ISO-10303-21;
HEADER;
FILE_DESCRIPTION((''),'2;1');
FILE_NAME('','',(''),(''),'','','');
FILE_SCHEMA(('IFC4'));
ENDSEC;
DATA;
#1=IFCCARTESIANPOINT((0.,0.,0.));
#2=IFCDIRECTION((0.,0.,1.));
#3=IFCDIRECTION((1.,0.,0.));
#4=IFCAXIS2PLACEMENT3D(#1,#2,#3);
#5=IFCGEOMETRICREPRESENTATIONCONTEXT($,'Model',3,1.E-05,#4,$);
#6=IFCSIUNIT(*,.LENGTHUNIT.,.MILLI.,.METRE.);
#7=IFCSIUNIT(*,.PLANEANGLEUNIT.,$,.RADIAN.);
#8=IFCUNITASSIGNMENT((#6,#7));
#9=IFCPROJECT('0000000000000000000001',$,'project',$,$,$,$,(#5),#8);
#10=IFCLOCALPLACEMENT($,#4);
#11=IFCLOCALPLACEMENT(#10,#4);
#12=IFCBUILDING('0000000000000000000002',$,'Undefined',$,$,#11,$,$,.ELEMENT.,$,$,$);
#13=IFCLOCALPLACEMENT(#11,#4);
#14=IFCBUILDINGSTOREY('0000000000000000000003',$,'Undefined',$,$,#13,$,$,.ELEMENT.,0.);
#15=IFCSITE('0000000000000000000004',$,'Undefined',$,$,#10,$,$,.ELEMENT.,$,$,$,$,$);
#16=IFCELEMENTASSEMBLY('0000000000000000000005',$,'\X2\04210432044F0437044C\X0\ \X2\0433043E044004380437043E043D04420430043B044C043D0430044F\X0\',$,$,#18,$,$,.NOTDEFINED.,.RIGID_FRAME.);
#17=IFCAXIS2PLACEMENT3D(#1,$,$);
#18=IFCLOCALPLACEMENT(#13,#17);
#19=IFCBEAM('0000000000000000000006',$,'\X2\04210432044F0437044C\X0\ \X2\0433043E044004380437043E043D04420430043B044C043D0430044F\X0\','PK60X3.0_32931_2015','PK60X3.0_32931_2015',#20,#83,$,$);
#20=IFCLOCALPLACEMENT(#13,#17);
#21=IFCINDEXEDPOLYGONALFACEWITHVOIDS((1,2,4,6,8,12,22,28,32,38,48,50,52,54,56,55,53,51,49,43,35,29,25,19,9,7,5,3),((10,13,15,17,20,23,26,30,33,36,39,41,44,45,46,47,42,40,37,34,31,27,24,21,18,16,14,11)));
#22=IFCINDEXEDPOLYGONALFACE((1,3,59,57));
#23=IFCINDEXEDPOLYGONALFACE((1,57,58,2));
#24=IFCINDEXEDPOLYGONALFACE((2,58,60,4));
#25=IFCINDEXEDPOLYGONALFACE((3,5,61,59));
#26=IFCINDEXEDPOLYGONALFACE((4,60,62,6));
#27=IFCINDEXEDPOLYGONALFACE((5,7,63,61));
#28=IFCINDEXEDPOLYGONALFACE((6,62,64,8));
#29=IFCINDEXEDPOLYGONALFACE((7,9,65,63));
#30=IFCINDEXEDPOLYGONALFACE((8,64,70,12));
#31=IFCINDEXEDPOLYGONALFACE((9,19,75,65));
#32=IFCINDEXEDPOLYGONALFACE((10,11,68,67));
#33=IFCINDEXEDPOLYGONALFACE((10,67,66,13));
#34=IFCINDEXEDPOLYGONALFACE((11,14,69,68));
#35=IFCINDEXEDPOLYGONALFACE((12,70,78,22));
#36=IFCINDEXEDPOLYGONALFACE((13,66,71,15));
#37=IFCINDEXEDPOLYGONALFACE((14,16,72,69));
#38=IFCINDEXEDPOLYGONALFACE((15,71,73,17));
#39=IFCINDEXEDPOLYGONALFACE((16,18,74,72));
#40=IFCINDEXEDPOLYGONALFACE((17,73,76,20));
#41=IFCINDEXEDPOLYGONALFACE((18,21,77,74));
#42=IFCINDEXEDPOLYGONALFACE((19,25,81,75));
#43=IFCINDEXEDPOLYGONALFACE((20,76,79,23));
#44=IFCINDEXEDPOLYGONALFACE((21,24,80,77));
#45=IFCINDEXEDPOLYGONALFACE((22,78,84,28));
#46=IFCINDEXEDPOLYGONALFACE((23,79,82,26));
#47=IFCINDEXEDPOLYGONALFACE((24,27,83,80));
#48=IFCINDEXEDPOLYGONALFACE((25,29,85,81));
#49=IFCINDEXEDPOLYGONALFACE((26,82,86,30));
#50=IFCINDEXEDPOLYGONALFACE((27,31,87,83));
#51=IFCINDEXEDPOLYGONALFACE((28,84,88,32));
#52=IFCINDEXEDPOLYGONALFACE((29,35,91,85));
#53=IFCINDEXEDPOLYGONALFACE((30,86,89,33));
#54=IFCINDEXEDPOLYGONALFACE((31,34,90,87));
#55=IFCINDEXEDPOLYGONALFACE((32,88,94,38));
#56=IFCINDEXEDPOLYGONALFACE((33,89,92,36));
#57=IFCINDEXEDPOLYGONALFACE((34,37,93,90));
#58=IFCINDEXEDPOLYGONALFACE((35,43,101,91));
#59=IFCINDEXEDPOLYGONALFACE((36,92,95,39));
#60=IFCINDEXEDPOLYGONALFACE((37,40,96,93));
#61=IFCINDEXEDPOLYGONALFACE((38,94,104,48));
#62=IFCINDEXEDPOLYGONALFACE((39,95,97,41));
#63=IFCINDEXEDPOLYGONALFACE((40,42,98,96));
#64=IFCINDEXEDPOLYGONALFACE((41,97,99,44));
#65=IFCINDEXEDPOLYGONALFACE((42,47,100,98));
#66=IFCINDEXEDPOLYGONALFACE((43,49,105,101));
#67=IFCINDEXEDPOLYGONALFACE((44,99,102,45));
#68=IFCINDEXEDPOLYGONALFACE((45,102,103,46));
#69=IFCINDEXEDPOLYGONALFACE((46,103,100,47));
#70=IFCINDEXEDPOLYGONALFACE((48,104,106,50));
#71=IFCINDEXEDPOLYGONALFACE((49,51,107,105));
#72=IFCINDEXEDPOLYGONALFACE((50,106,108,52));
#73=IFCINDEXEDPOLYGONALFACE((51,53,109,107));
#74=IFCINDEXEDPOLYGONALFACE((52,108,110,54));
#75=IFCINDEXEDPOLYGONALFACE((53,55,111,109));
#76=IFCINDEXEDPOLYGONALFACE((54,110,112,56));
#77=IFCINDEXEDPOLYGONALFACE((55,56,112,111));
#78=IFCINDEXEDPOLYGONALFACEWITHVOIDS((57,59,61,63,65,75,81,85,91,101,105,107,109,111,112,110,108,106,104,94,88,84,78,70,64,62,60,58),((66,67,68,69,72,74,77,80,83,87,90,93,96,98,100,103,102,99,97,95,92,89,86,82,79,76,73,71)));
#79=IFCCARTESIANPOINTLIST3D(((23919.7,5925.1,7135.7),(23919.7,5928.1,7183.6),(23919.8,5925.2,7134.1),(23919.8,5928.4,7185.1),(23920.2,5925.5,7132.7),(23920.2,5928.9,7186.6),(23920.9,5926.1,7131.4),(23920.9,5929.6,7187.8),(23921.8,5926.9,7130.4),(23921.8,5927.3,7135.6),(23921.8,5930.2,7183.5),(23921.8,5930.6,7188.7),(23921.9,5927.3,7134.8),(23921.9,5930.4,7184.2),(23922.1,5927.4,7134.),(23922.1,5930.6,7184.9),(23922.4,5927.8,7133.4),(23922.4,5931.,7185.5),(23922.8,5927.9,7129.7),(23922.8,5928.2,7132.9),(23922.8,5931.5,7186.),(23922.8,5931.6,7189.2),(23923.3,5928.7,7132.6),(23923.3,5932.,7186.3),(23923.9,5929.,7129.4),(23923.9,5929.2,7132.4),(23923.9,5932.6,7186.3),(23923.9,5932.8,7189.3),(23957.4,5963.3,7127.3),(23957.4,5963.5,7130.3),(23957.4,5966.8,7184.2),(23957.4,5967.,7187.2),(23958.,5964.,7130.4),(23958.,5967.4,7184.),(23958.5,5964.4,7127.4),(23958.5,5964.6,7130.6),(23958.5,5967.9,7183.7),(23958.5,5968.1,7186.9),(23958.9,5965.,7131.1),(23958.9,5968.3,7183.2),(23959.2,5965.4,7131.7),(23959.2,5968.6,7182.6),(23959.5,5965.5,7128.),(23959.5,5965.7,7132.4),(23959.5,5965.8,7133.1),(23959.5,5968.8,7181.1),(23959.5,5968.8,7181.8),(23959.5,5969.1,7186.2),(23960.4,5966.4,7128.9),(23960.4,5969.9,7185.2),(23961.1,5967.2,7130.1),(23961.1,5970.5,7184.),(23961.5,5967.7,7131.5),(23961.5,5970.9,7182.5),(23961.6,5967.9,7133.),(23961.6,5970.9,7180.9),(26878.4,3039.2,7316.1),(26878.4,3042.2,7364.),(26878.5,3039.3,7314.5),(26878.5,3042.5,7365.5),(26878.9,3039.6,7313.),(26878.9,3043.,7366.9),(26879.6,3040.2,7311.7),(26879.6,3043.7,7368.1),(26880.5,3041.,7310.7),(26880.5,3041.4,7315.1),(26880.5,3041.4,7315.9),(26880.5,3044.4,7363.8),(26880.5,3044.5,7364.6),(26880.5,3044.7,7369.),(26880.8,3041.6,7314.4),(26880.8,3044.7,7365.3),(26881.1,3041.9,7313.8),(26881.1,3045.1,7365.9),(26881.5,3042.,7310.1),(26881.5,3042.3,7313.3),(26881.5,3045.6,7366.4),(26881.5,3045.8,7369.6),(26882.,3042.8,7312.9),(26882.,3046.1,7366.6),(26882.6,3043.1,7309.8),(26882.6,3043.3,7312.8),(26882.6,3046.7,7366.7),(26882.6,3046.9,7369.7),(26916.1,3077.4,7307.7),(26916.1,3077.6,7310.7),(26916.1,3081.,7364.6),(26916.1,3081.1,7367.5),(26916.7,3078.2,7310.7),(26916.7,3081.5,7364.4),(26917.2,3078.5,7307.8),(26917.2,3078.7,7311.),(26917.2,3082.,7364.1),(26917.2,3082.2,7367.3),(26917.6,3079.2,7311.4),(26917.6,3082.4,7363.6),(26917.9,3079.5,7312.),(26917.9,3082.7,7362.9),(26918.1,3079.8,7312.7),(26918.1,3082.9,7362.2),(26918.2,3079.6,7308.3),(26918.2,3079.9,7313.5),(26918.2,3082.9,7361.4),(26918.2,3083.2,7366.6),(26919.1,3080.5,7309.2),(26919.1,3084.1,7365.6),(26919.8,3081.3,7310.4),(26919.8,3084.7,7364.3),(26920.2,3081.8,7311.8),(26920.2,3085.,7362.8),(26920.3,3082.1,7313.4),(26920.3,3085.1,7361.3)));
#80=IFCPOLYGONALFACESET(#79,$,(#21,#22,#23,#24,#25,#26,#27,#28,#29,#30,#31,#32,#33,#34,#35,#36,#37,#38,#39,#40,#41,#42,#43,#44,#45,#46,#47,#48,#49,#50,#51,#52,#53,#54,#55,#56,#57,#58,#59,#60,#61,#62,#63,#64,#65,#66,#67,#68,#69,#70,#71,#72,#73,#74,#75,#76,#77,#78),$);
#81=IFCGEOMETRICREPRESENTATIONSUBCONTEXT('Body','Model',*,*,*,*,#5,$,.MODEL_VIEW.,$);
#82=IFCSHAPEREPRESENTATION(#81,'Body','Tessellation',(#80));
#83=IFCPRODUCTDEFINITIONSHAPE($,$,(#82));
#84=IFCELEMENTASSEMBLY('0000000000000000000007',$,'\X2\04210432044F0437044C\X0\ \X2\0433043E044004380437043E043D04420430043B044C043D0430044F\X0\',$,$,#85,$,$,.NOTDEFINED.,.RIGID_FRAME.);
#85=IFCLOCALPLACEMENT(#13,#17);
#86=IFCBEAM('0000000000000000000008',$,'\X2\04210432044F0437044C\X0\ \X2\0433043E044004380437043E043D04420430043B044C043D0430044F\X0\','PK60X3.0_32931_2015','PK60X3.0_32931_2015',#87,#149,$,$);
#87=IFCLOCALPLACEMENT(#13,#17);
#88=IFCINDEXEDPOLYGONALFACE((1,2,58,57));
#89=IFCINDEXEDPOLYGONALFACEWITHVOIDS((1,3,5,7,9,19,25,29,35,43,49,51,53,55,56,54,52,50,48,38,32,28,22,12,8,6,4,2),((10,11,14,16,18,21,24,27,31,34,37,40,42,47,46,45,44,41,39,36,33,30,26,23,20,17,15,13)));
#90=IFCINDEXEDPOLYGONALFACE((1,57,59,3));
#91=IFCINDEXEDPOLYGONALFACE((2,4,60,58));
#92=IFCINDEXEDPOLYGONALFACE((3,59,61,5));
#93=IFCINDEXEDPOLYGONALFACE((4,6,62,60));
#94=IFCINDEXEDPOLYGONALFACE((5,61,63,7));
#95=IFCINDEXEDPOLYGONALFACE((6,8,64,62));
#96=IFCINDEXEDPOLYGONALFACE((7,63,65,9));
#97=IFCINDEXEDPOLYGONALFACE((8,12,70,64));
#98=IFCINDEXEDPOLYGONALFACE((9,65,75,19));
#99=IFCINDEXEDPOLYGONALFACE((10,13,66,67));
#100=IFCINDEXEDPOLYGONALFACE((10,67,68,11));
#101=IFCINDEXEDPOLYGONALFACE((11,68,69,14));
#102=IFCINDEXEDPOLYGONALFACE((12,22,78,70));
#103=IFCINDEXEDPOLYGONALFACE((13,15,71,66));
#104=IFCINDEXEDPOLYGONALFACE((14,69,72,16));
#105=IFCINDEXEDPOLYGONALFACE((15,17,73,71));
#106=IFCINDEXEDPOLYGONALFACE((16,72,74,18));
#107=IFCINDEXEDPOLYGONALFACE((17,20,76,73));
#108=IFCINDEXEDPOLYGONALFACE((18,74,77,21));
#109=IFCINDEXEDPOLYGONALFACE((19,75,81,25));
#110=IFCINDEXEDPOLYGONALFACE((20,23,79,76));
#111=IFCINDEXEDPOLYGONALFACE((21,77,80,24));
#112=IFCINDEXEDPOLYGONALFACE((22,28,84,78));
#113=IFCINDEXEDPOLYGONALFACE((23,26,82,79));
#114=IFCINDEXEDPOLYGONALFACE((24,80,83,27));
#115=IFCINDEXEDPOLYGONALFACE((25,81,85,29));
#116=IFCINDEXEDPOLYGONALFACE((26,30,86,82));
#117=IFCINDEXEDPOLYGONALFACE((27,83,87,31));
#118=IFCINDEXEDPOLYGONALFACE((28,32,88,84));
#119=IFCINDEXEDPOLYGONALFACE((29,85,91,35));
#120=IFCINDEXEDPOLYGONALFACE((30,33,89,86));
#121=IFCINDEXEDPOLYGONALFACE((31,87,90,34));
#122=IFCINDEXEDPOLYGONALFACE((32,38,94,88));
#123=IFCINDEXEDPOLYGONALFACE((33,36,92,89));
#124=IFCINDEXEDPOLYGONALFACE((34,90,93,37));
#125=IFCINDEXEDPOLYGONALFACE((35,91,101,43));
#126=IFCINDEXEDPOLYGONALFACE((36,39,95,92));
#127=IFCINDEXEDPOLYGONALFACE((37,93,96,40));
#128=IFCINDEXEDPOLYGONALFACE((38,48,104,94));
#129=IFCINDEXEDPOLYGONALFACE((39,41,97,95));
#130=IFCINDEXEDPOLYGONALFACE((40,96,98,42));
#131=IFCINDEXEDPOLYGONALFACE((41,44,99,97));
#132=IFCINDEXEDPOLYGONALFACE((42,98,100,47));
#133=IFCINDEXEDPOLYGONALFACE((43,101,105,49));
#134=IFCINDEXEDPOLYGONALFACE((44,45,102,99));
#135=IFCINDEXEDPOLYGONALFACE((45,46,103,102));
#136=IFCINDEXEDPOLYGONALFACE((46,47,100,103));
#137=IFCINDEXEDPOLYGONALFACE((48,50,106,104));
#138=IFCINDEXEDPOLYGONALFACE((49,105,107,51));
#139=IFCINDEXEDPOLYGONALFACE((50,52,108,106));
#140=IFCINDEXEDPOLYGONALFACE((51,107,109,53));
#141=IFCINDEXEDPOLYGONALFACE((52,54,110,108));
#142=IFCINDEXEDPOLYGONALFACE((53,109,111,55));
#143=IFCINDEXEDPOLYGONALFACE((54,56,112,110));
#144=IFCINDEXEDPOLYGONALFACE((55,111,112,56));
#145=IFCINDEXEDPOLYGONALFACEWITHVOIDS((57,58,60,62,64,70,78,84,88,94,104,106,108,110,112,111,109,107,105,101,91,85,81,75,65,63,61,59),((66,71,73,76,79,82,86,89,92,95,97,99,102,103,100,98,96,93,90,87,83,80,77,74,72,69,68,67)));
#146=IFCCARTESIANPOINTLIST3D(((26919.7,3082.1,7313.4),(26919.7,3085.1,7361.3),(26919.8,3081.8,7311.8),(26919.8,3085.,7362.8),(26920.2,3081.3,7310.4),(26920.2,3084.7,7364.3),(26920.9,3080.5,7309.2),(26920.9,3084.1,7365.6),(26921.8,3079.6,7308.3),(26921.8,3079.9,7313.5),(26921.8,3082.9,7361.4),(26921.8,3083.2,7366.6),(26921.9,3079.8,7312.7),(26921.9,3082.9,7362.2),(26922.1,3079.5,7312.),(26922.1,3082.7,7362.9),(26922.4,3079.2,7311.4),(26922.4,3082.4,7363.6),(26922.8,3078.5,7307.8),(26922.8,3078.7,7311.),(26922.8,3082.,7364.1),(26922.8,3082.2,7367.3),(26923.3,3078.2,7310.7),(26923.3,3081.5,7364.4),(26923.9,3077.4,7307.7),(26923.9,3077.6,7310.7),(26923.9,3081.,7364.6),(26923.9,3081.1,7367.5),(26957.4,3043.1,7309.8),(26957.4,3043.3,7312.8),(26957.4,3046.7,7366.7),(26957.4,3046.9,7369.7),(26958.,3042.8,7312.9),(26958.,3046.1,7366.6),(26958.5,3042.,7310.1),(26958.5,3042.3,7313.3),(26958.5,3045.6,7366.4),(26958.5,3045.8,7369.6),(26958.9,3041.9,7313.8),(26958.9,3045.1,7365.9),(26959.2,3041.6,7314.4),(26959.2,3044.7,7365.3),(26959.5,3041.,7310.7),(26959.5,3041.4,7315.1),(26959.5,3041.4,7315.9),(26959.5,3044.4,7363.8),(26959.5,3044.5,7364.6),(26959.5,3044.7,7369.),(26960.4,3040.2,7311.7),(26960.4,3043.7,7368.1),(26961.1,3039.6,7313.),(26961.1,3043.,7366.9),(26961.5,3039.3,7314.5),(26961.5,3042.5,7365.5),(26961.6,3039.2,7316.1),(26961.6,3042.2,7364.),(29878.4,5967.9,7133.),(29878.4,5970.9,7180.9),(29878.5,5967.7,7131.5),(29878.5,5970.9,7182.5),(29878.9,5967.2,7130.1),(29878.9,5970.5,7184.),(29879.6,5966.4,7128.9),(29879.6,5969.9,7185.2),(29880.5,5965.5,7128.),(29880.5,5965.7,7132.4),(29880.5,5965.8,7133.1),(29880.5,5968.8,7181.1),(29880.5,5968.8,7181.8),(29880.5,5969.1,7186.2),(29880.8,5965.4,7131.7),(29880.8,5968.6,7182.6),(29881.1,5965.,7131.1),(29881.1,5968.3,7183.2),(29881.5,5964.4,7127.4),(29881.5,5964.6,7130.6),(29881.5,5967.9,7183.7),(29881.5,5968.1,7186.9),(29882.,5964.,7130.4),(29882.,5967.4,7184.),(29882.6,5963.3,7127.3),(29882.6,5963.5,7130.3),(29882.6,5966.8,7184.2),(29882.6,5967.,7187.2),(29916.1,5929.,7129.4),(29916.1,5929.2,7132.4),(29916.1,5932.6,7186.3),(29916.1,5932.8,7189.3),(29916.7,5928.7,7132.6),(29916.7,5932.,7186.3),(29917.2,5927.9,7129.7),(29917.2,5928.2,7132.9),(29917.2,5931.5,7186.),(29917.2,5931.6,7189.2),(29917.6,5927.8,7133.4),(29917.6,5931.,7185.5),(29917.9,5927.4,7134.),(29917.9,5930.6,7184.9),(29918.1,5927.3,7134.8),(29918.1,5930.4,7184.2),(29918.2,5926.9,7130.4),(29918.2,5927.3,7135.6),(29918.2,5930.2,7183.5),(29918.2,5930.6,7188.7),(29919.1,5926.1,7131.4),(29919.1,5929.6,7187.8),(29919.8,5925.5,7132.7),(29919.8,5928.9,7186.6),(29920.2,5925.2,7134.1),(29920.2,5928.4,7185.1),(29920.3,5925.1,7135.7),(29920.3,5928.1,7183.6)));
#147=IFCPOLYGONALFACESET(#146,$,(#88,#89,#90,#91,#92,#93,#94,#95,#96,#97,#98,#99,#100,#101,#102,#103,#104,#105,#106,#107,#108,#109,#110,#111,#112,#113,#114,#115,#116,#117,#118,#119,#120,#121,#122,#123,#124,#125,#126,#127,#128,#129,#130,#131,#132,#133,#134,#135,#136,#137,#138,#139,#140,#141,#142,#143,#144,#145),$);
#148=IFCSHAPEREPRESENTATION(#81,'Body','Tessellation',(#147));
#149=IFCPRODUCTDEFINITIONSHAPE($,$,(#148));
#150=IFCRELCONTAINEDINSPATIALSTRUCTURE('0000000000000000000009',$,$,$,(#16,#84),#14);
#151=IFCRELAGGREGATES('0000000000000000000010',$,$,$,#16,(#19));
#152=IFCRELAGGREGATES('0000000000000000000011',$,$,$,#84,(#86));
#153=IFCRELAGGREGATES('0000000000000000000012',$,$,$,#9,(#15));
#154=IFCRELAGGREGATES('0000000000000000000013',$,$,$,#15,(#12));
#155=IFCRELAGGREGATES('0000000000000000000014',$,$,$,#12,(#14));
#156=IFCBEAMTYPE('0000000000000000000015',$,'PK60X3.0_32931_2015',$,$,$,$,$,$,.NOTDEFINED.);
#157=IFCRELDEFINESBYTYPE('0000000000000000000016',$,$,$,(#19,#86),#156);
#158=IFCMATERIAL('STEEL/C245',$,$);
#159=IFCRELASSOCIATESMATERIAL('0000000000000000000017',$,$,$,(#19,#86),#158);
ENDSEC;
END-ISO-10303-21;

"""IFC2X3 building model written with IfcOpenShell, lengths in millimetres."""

from ifc_helpers import new_model, si_unit, frame, origin_with_axes, origin_2d_with_axis, place, context, subcontext, project, spatial, hollow_rectangle, extrude, material, type_object, element, aggregate, save


model = new_model("IFC2X3")

# Units and contexts
model_context = context("Model", 3, precision=1e-05, world=origin_with_axes())
body_context = subcontext(model_context, "Body", "Model", "MODEL_VIEW")
ifc_project = project(units=[si_unit("LENGTHUNIT", "METRE", prefix="MILLI"), si_unit("PLANEANGLEUNIT", "RADIAN")], contexts=[model_context])

# Site, building, storey
site_placement = place(None, origin_with_axes())
site = spatial("IfcSite", under=ifc_project, at=site_placement, Name="Undefined", CompositionType="ELEMENT")
building_placement = place(site_placement, origin_with_axes())
building = spatial("IfcBuilding", under=site, at=building_placement, Name="Undefined", CompositionType="ELEMENT")
storey_placement = place(building_placement, origin_with_axes())
storey = spatial("IfcBuildingStorey", under=building, at=storey_placement, Name="Undefined", CompositionType="ELEMENT", Elevation=0.0)

# Shared definitions
ifc_material = material(Name="STEEL/C245")

# Element assemblies, beams
beam_type_1 = type_object("IfcBeamType", Name="PK60X3.0_32931_2015", PredefinedType="NOTDEFINED")
assembly_1_placement = place(storey_placement, origin_with_axes())
assembly_1 = element("IfcElementAssembly", 1, at=assembly_1_placement, inside=storey, Name="Связь горизонтальная", AssemblyPlace="NOTDEFINED", PredefinedType="RIGID_FRAME")
beam_1_placement = place(assembly_1_placement, frame((23940.7, 5948.0, 7158.3), z_axis=(0.0, 0.062378, 0.998053), x_axis=(0.715179, -0.69758, 0.043599)))
beam_1 = element("IfcBeam", 2, at=beam_1_placement, type_object=beam_type_1, material=ifc_material, Name="Связь горизонтальная", Description="PK60X3.0_32931_2015", ObjectType="PK60X3.0_32931_2015", context=body_context, shape_type="SweptSolid", body=[
    extrude(hollow_rectangle(XDim=60.0, YDim=60.0, WallThickness=3.0, InnerFilletRadius=3.0, OuterFilletRadius=6.0, at=origin_2d_with_axis()), frame((4137.0, 0.0, 0.0), z_axis=(-1.0, 0.0, 0.0), x_axis=(0.0, -1.0, 0.0)), (0.0, 0.0, 1.0), 4137.0),
])
aggregate(assembly_1, [beam_1])
assembly_2_placement = place(storey_placement, origin_with_axes())
assembly_2 = element("IfcElementAssembly", 3, at=assembly_2_placement, inside=storey, Name="Связь горизонтальная", AssemblyPlace="NOTDEFINED", PredefinedType="RIGID_FRAME")
beam_2_placement = place(assembly_2_placement, frame((29899.3, 5948.0, 7158.3), z_axis=(0.0, 0.062378, 0.998053), x_axis=(-0.715179, -0.69758, 0.043599)))
beam_2 = element("IfcBeam", 4, at=beam_2_placement, type_object=beam_type_1, material=ifc_material, Name="Связь горизонтальная", Description="PK60X3.0_32931_2015", ObjectType="PK60X3.0_32931_2015", context=body_context, shape_type="SweptSolid", body=[
    extrude(hollow_rectangle(XDim=60.0, YDim=60.0, WallThickness=3.0, InnerFilletRadius=3.0, OuterFilletRadius=6.0, at=origin_2d_with_axis()), frame((4137.0, 0.0, 0.0), z_axis=(-1.0, 0.0, 0.0), x_axis=(0.0, -1.0, 0.0)), (0.0, 0.0, 1.0), 4137.0),
])
aggregate(assembly_2, [beam_2])

save(model, "model.ifc")
